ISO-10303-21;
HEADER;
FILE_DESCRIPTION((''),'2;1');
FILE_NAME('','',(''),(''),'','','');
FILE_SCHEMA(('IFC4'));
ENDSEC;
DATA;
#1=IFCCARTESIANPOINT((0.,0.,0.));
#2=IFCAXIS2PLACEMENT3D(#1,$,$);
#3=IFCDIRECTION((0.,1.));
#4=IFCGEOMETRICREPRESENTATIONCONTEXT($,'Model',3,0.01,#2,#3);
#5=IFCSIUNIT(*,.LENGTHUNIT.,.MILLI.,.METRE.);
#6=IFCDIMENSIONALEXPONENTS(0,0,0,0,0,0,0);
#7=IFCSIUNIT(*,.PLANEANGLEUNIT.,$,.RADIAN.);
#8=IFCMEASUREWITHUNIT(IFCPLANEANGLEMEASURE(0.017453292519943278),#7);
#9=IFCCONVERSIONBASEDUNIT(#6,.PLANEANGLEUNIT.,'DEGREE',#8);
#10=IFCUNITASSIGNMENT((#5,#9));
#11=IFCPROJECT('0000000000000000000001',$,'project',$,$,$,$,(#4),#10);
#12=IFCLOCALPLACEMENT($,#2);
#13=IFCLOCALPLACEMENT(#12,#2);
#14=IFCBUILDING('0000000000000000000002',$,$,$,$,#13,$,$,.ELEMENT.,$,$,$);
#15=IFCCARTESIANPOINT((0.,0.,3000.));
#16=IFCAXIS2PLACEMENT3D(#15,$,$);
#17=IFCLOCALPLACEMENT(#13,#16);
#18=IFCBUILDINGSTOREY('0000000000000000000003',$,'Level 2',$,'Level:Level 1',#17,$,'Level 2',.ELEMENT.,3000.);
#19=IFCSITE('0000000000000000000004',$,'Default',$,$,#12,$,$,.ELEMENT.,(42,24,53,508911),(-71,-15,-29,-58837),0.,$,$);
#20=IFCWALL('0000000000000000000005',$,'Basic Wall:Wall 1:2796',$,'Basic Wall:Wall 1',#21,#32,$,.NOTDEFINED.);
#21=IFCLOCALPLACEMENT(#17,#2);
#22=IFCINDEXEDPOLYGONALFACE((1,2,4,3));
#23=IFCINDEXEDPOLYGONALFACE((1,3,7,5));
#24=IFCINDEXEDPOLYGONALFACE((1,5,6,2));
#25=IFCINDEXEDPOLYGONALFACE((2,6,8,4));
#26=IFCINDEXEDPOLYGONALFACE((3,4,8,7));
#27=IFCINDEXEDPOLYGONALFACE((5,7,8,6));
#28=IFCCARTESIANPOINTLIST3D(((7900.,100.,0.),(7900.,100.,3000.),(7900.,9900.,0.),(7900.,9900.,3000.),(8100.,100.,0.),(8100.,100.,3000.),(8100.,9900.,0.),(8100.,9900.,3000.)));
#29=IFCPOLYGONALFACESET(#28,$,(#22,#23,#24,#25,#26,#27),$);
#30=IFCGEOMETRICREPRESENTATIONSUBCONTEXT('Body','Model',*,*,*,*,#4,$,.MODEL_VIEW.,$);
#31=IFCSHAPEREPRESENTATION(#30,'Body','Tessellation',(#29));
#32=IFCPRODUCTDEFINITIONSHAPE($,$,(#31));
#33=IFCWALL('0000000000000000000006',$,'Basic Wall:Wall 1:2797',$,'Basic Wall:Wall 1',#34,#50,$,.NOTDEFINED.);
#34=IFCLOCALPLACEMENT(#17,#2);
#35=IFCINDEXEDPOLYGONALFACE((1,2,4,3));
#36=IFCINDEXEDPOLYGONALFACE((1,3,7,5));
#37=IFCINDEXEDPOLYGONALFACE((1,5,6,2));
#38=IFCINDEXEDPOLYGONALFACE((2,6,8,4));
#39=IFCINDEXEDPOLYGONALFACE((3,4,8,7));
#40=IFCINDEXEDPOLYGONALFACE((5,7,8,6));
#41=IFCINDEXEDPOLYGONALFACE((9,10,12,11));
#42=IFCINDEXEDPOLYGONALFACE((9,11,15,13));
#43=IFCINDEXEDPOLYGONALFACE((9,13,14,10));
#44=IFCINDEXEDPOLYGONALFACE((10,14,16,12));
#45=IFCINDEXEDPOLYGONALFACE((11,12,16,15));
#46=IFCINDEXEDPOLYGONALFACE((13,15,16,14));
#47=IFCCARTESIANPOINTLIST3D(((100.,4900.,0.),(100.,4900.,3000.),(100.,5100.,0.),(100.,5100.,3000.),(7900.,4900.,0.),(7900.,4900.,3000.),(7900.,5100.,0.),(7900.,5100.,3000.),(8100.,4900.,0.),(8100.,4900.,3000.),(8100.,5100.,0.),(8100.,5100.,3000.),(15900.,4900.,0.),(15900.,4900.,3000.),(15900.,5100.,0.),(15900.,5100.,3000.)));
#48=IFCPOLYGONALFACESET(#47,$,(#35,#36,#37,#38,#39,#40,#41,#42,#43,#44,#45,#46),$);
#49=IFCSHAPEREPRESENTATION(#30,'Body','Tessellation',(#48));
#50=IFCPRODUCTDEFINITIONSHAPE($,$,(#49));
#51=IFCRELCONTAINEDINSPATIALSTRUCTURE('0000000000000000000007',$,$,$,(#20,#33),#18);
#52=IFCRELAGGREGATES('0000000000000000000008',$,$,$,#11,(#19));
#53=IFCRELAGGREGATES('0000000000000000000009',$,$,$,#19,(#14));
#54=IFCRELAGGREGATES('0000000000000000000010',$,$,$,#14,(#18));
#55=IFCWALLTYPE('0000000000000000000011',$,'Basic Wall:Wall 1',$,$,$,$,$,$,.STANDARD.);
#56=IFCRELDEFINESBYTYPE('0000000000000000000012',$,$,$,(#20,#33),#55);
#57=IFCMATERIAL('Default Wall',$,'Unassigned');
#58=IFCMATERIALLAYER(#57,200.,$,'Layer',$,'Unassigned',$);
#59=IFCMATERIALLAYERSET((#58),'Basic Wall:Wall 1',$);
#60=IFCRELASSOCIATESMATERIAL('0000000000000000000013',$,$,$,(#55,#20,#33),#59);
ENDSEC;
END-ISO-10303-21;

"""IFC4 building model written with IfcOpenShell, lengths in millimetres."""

from ifc_helpers import new_model, entity, si_unit, converted_unit, direction, frame, frame_2d, origin, origin_2d_with_axis, place, context, subcontext, project, spatial, rectangle, extrude, material, layer, layer_set, layer_usage, type_object, element, save


model = new_model("IFC4")

# Units and contexts
model_context = context("Model", 3, precision=0.01, world=origin(), true_north=direction((0.0, 1.0)))
body_context = subcontext(model_context, "Body", "Model", "MODEL_VIEW")
ifc_project = project(units=[si_unit("LENGTHUNIT", "METRE", prefix="MILLI"), converted_unit("PLANEANGLEUNIT", "DEGREE", entity("IfcPlaneAngleMeasure", 0.017453292519943278), si_unit("PLANEANGLEUNIT", "RADIAN"), dimensions=[0, 0, 0, 0, 0, 0, 0])], contexts=[model_context])

# Site, building, storey
site_placement = place(None, origin())
site = spatial("IfcSite", under=ifc_project, at=site_placement, Name="Default", CompositionType="ELEMENT", RefLatitude=(42, 24, 53, 508911), RefLongitude=(-71, -15, -29, -58837), RefElevation=0.0)
building_placement = place(site_placement, origin())
building = spatial("IfcBuilding", under=site, at=building_placement, CompositionType="ELEMENT")
storey_placement = place(building_placement, frame((0.0, 0.0, 3000.0)))
storey = spatial("IfcBuildingStorey", under=building, at=storey_placement, Name="Level 2", ObjectType="Level:Level 1", LongName="Level 2", CompositionType="ELEMENT", Elevation=3000.0)

# Wall
ifc_material_1 = material(Name="Default Wall", Category="Unassigned")
ifc_layer_1 = layer(ifc_material_1, 200.0, Name="Layer", Category="Unassigned")
ifc_layer_set_1 = layer_set([ifc_layer_1], Name="Basic Wall:Wall 1")
wall_type = type_object("IfcWallType", Name="Basic Wall:Wall 1", PredefinedType="STANDARD", material=ifc_layer_set_1)
ifc_layer_usage_1 = layer_usage(ifc_layer_set_1, "AXIS2", "NEGATIVE", 100.0)
wall_1_placement = place(storey_placement, frame((8000.0, 100.0, 0.0), z_axis=(0.0, 0.0, 1.0), x_axis=(0.0, 1.0, 0.0)))
element("IfcWall", 1, at=wall_1_placement, inside=storey, type_object=wall_type, material=ifc_layer_usage_1, Name="Basic Wall:Wall 1:2796", ObjectType="Basic Wall:Wall 1", PredefinedType="NOTDEFINED", context=body_context, shape_type="SweptSolid", body=[
    extrude(rectangle(XDim=9800.0, YDim=200.0, at=frame_2d((4900.0, 0.0), x_axis=(-1.0, 0.0))), origin(), (0.0, 0.0, 1.0), 3000.0),
])

# Wall, opening
ifc_layer_usage_2 = layer_usage(ifc_layer_set_1, "AXIS2", "NEGATIVE", 100.0)
wall_2_placement = place(storey_placement, frame((100.0, 5000.0, 0.0)))
wall_2 = element("IfcWall", 2, at=wall_2_placement, inside=storey, type_object=wall_type, material=ifc_layer_usage_2, Name="Basic Wall:Wall 1:2797", ObjectType="Basic Wall:Wall 1", PredefinedType="NOTDEFINED", context=body_context, shape_type="SweptSolid", body=[
    extrude(rectangle(XDim=15800.0, YDim=200.0, at=frame_2d((7900.0, 0.0), x_axis=(-1.0, 0.0))), origin(), (0.0, 0.0, 1.0), 3000.0),
])
opening_placement = place(storey_placement, frame((100.0, 5000.0, 0.0)))
element("IfcOpeningElement", 3, at=opening_placement, cuts=wall_2, PredefinedType="OPENING", context=body_context, shape_type="SweptSolid", body=[
    extrude(rectangle(XDim=3000.0, YDim=200.0, at=origin_2d_with_axis()), frame((7800.0, 0.0, 1500.0), z_axis=(1.0, 0.0, 0.0), x_axis=(0.0, 0.0, -1.0)), (0.0, 0.0, 1.0), 200.0),
])

save(model, "model.ifc")
